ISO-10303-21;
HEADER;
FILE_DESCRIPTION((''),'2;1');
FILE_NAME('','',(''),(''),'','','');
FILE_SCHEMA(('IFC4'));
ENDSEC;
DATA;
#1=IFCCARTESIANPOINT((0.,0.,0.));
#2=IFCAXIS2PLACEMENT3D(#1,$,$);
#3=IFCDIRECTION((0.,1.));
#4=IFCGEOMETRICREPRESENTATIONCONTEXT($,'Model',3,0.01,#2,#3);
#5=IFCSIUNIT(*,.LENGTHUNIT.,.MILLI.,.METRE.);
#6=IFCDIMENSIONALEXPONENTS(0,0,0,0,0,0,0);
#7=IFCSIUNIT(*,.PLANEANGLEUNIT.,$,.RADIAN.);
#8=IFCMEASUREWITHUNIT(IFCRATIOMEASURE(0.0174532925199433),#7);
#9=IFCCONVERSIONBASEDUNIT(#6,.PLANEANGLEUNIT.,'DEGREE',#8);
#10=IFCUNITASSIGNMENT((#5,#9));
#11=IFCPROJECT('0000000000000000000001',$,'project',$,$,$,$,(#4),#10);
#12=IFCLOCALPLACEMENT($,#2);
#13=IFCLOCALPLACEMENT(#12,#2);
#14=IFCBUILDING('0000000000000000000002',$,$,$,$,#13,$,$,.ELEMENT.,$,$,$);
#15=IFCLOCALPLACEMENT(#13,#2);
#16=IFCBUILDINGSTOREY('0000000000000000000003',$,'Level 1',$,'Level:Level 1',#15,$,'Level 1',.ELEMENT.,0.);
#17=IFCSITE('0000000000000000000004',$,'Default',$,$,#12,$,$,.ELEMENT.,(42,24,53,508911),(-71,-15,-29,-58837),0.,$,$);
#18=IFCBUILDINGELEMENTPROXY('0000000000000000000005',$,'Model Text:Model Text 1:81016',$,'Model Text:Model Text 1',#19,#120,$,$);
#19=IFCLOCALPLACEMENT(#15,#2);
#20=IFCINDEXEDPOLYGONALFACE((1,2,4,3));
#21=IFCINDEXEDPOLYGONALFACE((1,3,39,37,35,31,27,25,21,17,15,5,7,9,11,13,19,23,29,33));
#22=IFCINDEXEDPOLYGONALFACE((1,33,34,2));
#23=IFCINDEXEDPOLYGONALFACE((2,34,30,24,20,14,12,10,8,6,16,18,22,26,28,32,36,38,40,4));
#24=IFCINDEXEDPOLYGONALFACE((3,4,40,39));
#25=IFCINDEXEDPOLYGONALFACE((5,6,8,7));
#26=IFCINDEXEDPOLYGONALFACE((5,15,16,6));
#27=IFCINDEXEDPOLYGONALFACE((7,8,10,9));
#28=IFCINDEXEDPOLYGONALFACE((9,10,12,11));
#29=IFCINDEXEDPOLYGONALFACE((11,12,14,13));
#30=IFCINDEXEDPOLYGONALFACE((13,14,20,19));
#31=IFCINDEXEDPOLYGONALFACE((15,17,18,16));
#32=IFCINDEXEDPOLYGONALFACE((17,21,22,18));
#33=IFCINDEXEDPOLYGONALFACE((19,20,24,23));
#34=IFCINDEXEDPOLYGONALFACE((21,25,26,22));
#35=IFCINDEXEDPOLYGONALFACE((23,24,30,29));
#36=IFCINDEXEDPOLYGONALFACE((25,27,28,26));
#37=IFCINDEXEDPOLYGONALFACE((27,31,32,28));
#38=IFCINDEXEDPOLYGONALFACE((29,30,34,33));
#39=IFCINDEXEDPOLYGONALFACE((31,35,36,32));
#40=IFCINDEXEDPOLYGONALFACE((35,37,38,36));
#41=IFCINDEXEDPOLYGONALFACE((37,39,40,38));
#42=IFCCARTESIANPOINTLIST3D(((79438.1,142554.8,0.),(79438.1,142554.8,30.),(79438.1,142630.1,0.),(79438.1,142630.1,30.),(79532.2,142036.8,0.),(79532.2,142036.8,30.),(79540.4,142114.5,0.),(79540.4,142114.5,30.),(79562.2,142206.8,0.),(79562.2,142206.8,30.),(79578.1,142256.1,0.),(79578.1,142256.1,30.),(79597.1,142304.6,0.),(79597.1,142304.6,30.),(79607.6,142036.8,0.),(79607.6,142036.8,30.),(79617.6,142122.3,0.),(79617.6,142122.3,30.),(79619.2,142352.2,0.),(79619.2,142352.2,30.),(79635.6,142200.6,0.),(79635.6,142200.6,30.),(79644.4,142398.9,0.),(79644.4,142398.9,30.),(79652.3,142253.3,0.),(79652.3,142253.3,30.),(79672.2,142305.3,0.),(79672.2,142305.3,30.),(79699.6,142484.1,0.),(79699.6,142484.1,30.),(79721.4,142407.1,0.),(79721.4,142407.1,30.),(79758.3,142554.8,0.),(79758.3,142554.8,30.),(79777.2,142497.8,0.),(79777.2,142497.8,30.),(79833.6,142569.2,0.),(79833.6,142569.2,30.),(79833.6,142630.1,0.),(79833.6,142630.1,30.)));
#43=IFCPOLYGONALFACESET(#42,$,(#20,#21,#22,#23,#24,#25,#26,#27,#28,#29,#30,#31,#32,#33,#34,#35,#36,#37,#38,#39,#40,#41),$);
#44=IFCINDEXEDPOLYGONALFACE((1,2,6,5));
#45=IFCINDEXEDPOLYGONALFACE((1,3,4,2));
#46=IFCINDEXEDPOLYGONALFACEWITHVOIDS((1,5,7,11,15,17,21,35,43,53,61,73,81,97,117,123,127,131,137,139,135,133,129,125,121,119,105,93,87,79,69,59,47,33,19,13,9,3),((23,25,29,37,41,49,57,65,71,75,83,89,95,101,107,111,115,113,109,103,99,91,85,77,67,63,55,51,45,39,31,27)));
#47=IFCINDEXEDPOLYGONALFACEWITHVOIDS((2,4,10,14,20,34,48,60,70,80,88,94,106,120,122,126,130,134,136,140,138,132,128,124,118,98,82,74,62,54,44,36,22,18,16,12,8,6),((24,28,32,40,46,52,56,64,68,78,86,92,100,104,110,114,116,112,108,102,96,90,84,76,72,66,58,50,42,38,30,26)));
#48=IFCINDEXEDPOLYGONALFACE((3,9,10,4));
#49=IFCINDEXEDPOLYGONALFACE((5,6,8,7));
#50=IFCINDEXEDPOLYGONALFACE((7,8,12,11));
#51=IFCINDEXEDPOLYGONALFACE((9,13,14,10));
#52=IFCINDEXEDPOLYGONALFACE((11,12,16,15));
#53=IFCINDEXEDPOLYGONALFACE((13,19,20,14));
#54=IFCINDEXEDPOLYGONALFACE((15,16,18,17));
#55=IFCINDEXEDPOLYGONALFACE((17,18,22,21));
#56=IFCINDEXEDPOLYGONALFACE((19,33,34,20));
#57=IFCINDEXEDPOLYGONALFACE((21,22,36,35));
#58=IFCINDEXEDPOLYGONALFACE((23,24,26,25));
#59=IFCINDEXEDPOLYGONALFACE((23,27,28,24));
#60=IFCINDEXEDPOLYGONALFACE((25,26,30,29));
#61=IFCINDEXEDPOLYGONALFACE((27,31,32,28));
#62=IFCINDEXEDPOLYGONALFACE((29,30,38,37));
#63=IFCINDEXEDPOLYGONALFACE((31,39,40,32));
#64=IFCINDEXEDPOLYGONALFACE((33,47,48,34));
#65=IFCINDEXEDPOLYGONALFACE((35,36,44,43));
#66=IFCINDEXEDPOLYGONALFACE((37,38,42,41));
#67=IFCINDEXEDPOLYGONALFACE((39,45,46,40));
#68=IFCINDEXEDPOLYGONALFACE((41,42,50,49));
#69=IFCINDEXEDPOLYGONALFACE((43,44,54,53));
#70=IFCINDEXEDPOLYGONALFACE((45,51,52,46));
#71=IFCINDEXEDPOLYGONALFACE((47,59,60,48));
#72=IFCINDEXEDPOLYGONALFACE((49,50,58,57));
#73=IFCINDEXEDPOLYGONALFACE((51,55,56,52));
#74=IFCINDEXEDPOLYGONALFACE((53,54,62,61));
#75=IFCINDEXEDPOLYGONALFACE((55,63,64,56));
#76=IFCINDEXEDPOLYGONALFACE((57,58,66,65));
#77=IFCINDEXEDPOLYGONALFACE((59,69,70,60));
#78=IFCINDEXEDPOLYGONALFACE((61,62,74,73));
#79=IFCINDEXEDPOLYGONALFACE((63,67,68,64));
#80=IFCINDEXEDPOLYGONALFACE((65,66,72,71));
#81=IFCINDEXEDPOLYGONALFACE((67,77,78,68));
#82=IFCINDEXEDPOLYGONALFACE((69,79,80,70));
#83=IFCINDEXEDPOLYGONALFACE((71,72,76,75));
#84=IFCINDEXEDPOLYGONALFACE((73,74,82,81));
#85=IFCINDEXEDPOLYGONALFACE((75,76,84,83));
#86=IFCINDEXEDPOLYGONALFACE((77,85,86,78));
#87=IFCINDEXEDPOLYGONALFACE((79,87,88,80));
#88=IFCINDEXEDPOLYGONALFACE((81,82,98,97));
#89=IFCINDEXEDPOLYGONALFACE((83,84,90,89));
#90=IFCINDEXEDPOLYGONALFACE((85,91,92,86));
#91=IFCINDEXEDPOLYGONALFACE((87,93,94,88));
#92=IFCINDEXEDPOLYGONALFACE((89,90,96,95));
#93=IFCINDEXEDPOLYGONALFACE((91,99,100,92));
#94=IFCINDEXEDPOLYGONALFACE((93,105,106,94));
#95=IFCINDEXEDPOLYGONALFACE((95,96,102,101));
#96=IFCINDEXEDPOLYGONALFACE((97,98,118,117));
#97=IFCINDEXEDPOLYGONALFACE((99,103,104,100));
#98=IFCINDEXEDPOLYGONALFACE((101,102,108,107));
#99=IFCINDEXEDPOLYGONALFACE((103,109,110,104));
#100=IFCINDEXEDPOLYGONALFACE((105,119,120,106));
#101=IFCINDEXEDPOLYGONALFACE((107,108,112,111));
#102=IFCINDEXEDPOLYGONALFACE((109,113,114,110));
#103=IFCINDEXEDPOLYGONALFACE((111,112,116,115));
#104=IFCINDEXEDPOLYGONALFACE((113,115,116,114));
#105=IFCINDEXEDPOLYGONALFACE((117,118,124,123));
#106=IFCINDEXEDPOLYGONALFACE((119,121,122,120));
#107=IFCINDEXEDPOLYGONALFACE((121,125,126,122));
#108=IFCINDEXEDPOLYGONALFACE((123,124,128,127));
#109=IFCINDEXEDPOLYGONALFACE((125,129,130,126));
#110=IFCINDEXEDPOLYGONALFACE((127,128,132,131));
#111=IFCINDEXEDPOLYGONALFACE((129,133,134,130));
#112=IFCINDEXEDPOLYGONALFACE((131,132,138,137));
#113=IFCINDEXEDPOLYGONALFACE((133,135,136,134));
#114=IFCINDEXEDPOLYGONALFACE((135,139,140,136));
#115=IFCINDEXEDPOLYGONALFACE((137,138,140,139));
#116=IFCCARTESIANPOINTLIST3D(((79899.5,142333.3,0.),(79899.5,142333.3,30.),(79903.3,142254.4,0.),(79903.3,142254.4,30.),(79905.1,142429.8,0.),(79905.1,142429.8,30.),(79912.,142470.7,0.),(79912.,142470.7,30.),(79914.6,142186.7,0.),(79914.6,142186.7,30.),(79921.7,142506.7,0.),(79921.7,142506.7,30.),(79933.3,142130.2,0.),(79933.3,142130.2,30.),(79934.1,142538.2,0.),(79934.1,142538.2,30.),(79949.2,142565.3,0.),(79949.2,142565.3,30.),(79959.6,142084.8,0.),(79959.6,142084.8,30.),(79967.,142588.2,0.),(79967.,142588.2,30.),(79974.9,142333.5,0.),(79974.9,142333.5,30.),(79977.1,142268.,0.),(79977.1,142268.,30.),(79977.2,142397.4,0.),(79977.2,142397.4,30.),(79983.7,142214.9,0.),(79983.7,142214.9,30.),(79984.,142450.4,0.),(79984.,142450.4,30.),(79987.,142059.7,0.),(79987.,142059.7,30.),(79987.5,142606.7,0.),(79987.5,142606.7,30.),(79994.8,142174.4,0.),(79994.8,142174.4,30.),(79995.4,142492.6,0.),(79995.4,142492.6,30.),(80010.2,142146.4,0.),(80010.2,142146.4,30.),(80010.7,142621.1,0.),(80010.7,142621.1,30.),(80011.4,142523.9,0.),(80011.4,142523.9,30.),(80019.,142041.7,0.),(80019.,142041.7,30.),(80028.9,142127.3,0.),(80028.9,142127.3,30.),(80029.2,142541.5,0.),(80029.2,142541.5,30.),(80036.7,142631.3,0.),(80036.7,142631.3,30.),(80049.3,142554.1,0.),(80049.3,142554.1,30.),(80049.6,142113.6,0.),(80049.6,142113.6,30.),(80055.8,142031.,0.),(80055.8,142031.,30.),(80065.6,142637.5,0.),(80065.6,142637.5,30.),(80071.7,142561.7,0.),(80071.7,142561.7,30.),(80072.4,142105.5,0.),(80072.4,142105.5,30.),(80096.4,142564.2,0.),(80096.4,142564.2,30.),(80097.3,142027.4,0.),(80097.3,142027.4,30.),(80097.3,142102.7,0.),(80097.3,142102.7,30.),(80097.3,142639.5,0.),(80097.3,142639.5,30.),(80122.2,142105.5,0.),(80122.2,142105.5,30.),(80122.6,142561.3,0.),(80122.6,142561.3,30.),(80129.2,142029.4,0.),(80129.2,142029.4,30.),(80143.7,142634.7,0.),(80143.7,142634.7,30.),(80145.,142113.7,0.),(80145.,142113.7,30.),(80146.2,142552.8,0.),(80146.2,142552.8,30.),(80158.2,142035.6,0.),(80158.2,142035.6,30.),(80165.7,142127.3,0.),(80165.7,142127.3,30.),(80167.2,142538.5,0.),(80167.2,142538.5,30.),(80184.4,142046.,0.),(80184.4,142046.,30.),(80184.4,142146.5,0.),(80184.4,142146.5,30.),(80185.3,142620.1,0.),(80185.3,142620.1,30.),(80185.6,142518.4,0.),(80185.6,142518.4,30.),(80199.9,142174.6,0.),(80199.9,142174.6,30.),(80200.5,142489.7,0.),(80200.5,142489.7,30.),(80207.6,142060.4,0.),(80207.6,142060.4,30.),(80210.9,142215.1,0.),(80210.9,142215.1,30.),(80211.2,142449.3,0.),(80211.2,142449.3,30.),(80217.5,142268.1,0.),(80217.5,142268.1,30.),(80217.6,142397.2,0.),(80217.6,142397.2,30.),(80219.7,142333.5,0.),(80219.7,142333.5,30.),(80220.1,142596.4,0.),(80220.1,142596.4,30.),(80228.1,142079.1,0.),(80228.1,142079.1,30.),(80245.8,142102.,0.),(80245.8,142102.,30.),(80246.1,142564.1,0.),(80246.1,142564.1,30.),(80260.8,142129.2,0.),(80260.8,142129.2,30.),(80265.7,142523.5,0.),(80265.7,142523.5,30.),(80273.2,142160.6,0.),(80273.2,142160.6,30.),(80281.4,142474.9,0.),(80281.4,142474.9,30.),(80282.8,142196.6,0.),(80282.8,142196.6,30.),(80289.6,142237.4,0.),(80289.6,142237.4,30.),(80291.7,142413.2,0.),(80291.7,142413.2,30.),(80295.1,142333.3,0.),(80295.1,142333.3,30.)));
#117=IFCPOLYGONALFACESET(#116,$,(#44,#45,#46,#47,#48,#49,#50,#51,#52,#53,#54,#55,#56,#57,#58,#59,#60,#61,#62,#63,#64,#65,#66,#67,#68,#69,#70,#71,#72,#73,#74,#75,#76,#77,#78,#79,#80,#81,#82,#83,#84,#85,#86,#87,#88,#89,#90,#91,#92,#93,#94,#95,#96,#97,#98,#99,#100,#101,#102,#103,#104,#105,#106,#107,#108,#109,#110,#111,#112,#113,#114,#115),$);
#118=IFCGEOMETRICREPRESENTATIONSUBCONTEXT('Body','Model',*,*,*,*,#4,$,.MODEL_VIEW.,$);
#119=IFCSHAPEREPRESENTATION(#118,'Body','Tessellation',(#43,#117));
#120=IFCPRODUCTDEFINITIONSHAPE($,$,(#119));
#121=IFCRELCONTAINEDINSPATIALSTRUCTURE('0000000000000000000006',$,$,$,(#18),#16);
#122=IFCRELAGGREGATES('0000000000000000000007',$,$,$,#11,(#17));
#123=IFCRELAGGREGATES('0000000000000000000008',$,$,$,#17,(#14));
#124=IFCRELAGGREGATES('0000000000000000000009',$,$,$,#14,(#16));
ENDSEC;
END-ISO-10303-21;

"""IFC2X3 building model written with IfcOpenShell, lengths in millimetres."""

from ifc_helpers import new_model, entity, si_unit, converted_unit, direction, frame, origin, place, context, subcontext, project, spatial, polyline, outline, extrude, element, save


model = new_model("IFC2X3")

# Units and contexts
model_context = context("Model", 3, precision=0.01, world=origin(), true_north=direction((0.0, 1.0)))
body_context = subcontext(model_context, "Body", "Model", "MODEL_VIEW")
ifc_project = project(units=[si_unit("LENGTHUNIT", "METRE", prefix="MILLI"), converted_unit("PLANEANGLEUNIT", "DEGREE", entity("IfcRatioMeasure", 0.0174532925199433), si_unit("PLANEANGLEUNIT", "RADIAN"), dimensions=[0, 0, 0, 0, 0, 0, 0])], contexts=[model_context])

# Site, building, storey
site_placement = place(None, origin())
site = spatial("IfcSite", under=ifc_project, at=site_placement, Name="Default", CompositionType="ELEMENT", RefLatitude=(42, 24, 53, 508911), RefLongitude=(-71, -15, -29, -58837), RefElevation=0.0)
building_placement = place(site_placement, origin())
building = spatial("IfcBuilding", under=site, at=building_placement, CompositionType="ELEMENT")
storey_placement = place(building_placement, origin())
storey = spatial("IfcBuildingStorey", under=building, at=storey_placement, Name="Level 1", ObjectType="Level:Level 1", LongName="Level 1", CompositionType="ELEMENT", Elevation=0.0)

# Building element proxy
proxy_1_placement = place(storey_placement, origin())
element("IfcBuildingElementProxy", 1, at=proxy_1_placement, inside=storey, Name="Model Text:Model Text 1:81016", ObjectType="Model Text:Model Text 1", context=body_context, shape_type="SweptSolid", body=[
    extrude(outline(polyline([(-199.9, -209.0), (-199.9, -284.3), (195.7, -284.3), (195.7, -223.4), (139.3, -152.0), (83.5, -61.3), (34.2, 40.5), (14.4, 92.5), (-2.4, 145.2), (-20.3, 223.5), (-30.3, 309.0), (-105.7, 309.0), (-97.5, 231.3), (-75.7, 139.0), (-59.9, 89.7), (-40.9, 41.2), (-18.8, -6.4), (6.4, -53.1), (61.7, -138.3), (120.3, -209.0), (-199.9, -209.0)])), frame((79637.9, 142345.8, 0.0), z_axis=(0.0, 0.0, -1.0), x_axis=(1.0, 0.0, 0.0)), (0.0, 0.0, -1.0), 30.0),
    extrude(outline(polyline([(-10.6, -198.7), (68.3, -198.7), (136.5, -190.7), (193.9, -174.7), (240.5, -150.6), (266.9, -124.4), (286.3, -93.2), (298.8, -57.0), (304.3, -15.7), (303.8, 16.2), (299.0, 45.5), (289.9, 72.1), (276.6, 96.0), (258.9, 117.3), (236.9, 136.2), (210.4, 152.5), (179.6, 166.3), (144.1, 177.6), (103.7, 186.3), (8.2, 196.4), (-71.8, 196.7), (-134.0, 189.4), (-183.3, 176.1), (-224.7, 158.4), (-258.2, 133.9), (-283.5, 100.3), (-300.1, 59.5), (-307.1, 13.4), (-306.6, -18.4), (-301.8, -47.5), (-292.8, -74.0), (-279.6, -97.9), (-262.0, -119.2), (-240.0, -138.1), (-213.6, -154.5), (-182.8, -168.4), (-147.3, -179.8), (-106.7, -188.6), (-10.6, -198.7)]), holes=[polyline([(-7.2, -123.5), (-71.0, -118.2), (-123.6, -108.8), (-165.2, -95.4), (-195.7, -78.0), (-212.4, -59.4), (-224.1, -38.7), (-230.6, -15.9), (-231.9, 8.9), (-227.8, 35.0), (-218.1, 58.1), (-202.8, 78.4), (-182.0, 95.8), (-152.6, 109.4), (-111.7, 118.1), (-59.4, 122.0), (4.4, 121.1), (69.6, 115.8), (122.2, 106.7), (162.2, 93.7), (189.5, 77.0), (207.7, 57.4), (220.4, 36.0), (227.5, 12.8), (229.1, -12.1), (225.2, -36.8), (215.9, -59.2), (201.3, -79.3), (181.4, -97.1), (152.6, -111.2), (111.6, -120.3), (58.3, -124.4), (-7.2, -123.5)])]), frame((80098.6, 142332.1, 0.0), z_axis=(0.0, 0.0, 1.0), x_axis=(0.047515, -0.998871, 0.0)), (0.0, 0.0, 1.0), 30.0),
])

save(model, "model.ifc")
